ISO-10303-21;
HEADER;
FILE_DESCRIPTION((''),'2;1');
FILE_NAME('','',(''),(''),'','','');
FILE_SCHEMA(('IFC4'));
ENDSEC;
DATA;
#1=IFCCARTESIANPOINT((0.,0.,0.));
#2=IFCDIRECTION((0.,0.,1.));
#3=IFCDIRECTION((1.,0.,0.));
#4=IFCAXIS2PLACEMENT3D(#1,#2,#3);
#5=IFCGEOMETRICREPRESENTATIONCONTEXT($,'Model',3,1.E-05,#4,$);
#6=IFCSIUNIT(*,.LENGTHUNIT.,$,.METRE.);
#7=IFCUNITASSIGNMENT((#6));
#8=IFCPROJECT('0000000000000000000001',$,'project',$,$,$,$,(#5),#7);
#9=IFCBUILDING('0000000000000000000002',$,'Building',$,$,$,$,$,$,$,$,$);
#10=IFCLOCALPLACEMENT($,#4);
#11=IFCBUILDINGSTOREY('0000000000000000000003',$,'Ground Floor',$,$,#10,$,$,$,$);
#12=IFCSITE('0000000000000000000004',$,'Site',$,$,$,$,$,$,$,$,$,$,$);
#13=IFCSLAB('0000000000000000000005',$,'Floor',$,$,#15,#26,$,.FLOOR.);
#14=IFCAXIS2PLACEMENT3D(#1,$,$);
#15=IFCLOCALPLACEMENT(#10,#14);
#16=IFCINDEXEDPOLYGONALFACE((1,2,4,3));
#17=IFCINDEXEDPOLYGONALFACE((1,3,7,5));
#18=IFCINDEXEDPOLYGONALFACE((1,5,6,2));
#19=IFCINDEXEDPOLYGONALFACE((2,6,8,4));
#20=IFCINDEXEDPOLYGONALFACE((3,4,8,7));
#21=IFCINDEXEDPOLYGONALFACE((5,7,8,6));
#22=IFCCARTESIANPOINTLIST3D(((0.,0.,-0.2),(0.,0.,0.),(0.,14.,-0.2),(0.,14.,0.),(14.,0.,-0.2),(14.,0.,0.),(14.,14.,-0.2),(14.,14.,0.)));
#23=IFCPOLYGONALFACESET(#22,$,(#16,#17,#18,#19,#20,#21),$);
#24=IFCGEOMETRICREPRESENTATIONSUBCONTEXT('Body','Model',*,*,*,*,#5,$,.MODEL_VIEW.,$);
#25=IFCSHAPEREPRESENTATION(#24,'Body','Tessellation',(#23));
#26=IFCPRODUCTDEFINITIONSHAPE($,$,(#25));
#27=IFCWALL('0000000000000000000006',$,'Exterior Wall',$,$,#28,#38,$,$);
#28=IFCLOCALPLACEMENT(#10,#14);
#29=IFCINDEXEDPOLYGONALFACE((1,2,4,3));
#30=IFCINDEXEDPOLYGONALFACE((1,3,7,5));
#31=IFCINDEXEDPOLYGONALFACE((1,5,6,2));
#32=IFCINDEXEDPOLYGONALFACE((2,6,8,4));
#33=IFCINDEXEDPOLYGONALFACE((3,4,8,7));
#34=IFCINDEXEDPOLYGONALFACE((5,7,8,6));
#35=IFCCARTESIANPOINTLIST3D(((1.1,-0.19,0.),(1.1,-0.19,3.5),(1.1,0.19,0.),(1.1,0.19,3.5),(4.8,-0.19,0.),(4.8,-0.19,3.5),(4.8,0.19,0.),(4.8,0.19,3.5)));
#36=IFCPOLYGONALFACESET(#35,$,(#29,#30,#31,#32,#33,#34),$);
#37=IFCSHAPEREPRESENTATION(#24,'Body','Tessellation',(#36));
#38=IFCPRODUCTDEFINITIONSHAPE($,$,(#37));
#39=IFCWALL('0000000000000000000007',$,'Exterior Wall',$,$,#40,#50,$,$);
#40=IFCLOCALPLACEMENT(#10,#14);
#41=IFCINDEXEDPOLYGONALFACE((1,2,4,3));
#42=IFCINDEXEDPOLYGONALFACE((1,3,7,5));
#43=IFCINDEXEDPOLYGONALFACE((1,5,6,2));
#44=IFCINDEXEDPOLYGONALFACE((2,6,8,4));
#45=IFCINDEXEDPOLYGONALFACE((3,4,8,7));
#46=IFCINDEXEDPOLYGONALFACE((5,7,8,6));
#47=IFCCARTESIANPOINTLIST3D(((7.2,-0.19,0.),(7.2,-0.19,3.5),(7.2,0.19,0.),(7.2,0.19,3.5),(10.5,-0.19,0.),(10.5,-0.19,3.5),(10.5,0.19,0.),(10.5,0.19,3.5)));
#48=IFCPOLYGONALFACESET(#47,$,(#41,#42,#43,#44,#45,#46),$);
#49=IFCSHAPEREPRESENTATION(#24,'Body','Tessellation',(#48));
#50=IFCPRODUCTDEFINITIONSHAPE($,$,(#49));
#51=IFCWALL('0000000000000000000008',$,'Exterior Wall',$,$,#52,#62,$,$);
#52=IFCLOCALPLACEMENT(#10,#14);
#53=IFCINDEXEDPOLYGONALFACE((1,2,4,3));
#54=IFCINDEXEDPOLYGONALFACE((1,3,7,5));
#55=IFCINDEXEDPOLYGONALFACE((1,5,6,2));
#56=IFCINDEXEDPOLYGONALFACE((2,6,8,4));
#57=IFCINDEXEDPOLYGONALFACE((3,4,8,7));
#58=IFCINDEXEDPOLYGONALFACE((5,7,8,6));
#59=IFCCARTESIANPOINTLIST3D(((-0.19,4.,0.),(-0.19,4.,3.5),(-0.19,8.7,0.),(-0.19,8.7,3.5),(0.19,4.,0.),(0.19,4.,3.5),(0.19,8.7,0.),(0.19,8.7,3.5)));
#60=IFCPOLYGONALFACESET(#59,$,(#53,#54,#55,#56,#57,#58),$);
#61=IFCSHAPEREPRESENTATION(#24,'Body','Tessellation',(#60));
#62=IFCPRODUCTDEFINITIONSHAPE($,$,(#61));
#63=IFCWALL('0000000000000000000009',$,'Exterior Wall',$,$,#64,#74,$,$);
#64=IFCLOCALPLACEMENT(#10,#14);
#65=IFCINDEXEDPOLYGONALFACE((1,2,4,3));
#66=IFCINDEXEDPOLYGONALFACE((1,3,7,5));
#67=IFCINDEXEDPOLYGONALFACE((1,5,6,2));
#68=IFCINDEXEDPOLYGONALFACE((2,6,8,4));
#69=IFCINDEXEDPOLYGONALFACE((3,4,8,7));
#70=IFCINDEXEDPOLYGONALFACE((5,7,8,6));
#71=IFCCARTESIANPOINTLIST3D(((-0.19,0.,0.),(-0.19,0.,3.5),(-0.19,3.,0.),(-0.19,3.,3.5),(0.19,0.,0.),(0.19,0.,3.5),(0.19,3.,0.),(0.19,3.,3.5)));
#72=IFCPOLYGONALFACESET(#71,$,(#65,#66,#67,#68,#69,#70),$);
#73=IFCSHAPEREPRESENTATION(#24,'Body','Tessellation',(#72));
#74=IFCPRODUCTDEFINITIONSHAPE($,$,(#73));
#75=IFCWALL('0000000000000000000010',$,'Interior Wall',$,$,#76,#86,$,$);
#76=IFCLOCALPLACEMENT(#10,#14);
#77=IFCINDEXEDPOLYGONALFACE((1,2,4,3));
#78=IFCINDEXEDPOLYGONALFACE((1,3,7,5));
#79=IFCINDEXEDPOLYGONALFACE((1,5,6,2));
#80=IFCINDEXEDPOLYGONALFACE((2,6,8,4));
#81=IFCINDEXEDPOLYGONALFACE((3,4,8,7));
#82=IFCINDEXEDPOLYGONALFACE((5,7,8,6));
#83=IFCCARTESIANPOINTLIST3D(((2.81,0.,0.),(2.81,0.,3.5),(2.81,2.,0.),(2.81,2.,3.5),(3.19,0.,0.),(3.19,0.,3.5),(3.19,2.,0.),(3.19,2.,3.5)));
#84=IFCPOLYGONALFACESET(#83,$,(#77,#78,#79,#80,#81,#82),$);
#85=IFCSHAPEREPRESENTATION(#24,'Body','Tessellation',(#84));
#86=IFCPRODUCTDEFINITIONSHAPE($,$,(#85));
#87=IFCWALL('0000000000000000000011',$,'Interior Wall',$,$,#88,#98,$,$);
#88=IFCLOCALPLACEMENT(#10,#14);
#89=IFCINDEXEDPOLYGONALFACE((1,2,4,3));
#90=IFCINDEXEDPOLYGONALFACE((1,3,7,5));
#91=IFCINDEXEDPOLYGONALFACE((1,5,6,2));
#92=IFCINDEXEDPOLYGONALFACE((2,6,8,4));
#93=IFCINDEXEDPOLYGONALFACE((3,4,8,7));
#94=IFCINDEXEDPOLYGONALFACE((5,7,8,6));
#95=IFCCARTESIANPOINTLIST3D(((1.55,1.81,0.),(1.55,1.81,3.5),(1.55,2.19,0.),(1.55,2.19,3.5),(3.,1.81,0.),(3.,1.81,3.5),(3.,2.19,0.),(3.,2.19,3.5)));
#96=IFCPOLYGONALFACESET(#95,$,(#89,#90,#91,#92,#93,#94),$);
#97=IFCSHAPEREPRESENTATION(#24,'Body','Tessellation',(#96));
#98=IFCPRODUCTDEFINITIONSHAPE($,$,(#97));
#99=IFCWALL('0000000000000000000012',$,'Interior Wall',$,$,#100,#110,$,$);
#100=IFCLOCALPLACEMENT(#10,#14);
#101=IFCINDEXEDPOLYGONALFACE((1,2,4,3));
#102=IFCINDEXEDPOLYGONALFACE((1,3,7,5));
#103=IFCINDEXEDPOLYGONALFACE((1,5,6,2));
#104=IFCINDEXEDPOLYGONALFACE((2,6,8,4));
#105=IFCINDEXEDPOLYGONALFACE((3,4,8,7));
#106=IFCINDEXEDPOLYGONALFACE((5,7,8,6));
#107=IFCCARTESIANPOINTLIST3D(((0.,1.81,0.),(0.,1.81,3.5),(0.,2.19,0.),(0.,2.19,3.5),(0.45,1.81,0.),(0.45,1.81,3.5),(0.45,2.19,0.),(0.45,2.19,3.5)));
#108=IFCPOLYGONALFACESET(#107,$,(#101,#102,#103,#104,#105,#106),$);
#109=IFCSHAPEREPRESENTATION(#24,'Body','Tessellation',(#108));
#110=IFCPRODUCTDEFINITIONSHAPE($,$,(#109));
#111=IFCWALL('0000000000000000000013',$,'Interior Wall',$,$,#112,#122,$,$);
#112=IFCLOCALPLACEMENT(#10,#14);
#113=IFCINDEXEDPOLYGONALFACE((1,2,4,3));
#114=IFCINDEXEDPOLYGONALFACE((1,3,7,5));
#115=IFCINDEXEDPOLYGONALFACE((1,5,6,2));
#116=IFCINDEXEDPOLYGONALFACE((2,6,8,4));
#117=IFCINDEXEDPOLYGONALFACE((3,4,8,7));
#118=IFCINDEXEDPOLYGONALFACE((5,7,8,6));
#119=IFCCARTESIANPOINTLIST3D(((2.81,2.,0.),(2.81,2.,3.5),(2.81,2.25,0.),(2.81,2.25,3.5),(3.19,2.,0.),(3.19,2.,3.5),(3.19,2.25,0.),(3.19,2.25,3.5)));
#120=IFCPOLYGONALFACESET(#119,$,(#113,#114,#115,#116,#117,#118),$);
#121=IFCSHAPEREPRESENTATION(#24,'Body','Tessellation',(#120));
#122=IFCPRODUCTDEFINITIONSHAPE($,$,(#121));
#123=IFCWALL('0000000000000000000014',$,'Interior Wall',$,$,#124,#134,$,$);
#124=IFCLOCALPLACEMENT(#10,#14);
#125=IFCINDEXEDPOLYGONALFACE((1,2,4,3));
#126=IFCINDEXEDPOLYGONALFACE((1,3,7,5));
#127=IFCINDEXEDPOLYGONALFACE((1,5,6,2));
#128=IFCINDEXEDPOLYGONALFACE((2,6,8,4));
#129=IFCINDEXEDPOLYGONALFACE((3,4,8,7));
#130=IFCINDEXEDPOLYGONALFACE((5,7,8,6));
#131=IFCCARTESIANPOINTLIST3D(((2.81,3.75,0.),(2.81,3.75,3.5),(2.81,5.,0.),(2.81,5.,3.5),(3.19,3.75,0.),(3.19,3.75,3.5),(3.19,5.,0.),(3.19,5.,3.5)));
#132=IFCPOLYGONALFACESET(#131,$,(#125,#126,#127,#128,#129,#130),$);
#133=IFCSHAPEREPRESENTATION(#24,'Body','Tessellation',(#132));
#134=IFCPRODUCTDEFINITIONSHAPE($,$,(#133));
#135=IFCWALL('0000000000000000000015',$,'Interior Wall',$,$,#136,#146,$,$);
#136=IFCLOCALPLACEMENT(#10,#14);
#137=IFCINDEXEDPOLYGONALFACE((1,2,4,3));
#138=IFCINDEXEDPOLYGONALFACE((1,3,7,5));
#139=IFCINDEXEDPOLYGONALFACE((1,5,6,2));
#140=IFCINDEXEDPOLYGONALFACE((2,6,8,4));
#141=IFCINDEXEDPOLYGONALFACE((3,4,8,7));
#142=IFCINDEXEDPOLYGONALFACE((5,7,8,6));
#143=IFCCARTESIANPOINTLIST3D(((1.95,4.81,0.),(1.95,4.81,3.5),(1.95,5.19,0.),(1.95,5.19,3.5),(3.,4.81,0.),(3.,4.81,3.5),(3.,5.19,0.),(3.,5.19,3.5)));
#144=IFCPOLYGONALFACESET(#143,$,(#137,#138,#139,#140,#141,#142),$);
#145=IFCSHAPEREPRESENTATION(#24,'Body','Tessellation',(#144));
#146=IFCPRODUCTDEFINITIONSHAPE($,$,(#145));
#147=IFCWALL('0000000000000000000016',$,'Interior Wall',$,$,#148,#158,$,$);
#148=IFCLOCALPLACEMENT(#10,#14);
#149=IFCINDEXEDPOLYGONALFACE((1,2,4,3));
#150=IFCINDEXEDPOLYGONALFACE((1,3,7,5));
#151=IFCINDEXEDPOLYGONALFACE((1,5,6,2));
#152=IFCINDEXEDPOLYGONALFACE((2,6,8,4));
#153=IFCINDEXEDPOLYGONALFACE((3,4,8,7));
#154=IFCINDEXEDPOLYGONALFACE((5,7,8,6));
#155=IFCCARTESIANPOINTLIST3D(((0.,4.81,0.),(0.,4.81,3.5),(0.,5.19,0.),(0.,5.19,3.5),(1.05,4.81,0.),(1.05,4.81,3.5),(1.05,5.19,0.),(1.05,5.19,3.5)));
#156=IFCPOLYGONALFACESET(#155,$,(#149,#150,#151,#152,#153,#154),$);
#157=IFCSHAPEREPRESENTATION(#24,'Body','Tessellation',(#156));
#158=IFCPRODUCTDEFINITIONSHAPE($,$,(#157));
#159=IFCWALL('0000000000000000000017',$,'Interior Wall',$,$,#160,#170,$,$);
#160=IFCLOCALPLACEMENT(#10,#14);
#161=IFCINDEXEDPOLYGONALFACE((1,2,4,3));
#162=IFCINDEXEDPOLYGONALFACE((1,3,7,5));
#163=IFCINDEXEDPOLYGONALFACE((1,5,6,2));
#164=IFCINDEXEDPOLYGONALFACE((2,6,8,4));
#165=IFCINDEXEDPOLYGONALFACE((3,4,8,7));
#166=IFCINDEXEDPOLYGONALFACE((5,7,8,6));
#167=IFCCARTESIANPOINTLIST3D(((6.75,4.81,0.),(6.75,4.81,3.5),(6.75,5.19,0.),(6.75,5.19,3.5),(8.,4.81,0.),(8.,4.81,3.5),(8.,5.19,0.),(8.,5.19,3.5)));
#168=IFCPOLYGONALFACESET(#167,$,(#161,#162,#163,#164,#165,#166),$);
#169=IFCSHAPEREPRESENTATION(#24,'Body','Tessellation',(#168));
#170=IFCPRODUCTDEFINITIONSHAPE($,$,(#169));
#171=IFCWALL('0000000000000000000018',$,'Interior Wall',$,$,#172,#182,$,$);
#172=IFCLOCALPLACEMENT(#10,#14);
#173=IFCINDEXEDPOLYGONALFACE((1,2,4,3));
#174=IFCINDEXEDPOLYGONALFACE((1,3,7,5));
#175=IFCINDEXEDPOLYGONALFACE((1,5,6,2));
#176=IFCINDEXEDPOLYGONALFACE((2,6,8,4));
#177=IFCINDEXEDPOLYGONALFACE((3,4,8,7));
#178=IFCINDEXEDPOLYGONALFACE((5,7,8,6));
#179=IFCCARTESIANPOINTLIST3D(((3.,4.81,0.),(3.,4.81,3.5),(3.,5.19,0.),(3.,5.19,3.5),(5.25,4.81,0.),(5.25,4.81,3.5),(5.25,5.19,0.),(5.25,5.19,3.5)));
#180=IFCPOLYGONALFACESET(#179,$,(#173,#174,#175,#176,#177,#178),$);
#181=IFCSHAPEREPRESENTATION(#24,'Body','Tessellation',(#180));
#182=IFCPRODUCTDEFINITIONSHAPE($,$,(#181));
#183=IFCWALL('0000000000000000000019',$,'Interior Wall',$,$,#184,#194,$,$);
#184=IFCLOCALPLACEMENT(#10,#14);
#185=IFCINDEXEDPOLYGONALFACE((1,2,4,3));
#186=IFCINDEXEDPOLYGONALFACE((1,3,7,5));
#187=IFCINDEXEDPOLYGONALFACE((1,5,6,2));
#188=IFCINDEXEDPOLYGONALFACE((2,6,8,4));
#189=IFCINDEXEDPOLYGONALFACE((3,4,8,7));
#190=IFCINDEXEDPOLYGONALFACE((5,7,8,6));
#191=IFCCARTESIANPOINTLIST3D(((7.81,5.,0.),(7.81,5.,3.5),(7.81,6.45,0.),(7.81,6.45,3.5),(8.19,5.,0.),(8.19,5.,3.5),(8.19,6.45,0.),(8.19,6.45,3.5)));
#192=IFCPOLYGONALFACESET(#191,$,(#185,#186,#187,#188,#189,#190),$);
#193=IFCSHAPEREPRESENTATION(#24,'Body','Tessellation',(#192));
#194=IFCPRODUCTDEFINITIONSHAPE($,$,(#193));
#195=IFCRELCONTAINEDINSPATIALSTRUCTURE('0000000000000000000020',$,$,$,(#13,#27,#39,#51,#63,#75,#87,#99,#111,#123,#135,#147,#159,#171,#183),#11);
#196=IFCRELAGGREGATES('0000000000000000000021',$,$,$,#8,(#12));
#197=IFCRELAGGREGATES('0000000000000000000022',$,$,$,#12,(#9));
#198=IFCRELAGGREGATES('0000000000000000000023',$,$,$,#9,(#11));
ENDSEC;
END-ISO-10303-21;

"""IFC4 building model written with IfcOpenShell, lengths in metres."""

from ifc_helpers import new_model, si_unit, frame, origin_with_axes, place, context, subcontext, project, spatial, indexed_curve, outline, extrude, element, save


model = new_model("IFC4")

# Units and contexts
model_context = context("Model", 3, precision=1e-05, world=origin_with_axes())
body_context = subcontext(model_context, "Body", "Model", "MODEL_VIEW")
ifc_project = project(units=[si_unit("LENGTHUNIT", "METRE")], contexts=[model_context])

# Site, building, storey
site = spatial("IfcSite", under=ifc_project, Name="Site")
building = spatial("IfcBuilding", under=site, Name="Building")
storey_placement = place(None, origin_with_axes())
storey = spatial("IfcBuildingStorey", under=building, at=storey_placement, Name="Ground Floor")

# Slab
slab_placement = place(storey_placement, frame((0.0, 0.0, -0.2), z_axis=(0.0, 0.0, 1.0), x_axis=(1.0, 0.0, 0.0)))
element("IfcSlab", 1, at=slab_placement, inside=storey, Name="Floor", PredefinedType="FLOOR", context=body_context, shape_type="SweptSolid", body=[
    extrude(outline(indexed_curve([(0.0, 0.0), (14.0, 0.0), (14.0, 14.0), (0.0, 14.0)])), None, (0.0, 0.0, 1.0), 0.2),
])

# Walls
wall_1_placement = place(storey_placement, frame((1.1, 0.0, 0.0), z_axis=(0.0, 0.0, 1.0), x_axis=(1.0, 0.0, 0.0)))
element("IfcWall", 2, at=wall_1_placement, inside=storey, Name="Exterior Wall", context=body_context, shape_type="SweptSolid", body=[
    extrude(outline(indexed_curve([(0.0, 0.0), (0.0, 0.38), (3.7, 0.38), (3.7, 0.0), (0.0, 0.0)], self_intersect=False)), frame((0.0, -0.19, 0.0), z_axis=(0.0, 0.0, 1.0), x_axis=(1.0, 0.0, 0.0)), (0.0, 0.0, 1.0), 3.5),
])
wall_2_placement = place(storey_placement, frame((7.2, 0.0, 0.0), z_axis=(0.0, 0.0, 1.0), x_axis=(1.0, 0.0, 0.0)))
element("IfcWall", 3, at=wall_2_placement, inside=storey, Name="Exterior Wall", context=body_context, shape_type="SweptSolid", body=[
    extrude(outline(indexed_curve([(0.0, 0.0), (0.0, 0.38), (3.3, 0.38), (3.3, 0.0), (0.0, 0.0)], self_intersect=False)), frame((0.0, -0.19, 0.0), z_axis=(0.0, 0.0, 1.0), x_axis=(1.0, 0.0, 0.0)), (0.0, 0.0, 1.0), 3.5),
])
wall_3_placement = place(storey_placement, frame((0.0, 8.7, 0.0), z_axis=(0.0, 0.0, 1.0), x_axis=(0.0, -1.0, 0.0)))
element("IfcWall", 4, at=wall_3_placement, inside=storey, Name="Exterior Wall", context=body_context, shape_type="SweptSolid", body=[
    extrude(outline(indexed_curve([(0.0, 0.0), (0.0, 0.38), (4.7, 0.38), (4.7, 0.0), (0.0, 0.0)], self_intersect=False)), frame((0.0, -0.19, 0.0), z_axis=(0.0, 0.0, 1.0), x_axis=(1.0, 0.0, 0.0)), (0.0, 0.0, 1.0), 3.5),
])
wall_4_placement = place(storey_placement, frame((0.0, 3.0, 0.0), z_axis=(0.0, 0.0, 1.0), x_axis=(0.0, -1.0, 0.0)))
element("IfcWall", 5, at=wall_4_placement, inside=storey, Name="Exterior Wall", context=body_context, shape_type="SweptSolid", body=[
    extrude(outline(indexed_curve([(0.0, 0.0), (0.0, 0.38), (3.0, 0.38), (3.0, 0.0), (0.0, 0.0)], self_intersect=False)), frame((0.0, -0.19, 0.0), z_axis=(0.0, 0.0, 1.0), x_axis=(1.0, 0.0, 0.0)), (0.0, 0.0, 1.0), 3.5),
])
wall_5_placement = place(storey_placement, frame((3.0, 0.0, 0.0), z_axis=(0.0, 0.0, 1.0), x_axis=(0.0, 1.0, 0.0)))
element("IfcWall", 6, at=wall_5_placement, inside=storey, Name="Interior Wall", context=body_context, shape_type="SweptSolid", body=[
    extrude(outline(indexed_curve([(0.0, 0.0), (0.0, 0.38), (2.0, 0.38), (2.0, 0.0), (0.0, 0.0)], self_intersect=False)), frame((0.0, -0.19, 0.0), z_axis=(0.0, 0.0, 1.0), x_axis=(1.0, 0.0, 0.0)), (0.0, 0.0, 1.0), 3.5),
])
wall_6_placement = place(storey_placement, frame((3.0, 2.0, 0.0), z_axis=(0.0, 0.0, 1.0), x_axis=(-1.0, 0.0, 0.0)))
element("IfcWall", 7, at=wall_6_placement, inside=storey, Name="Interior Wall", context=body_context, shape_type="SweptSolid", body=[
    extrude(outline(indexed_curve([(0.0, 0.0), (0.0, 0.38), (1.45, 0.38), (1.45, 0.0), (0.0, 0.0)], self_intersect=False)), frame((0.0, -0.19, 0.0), z_axis=(0.0, 0.0, 1.0), x_axis=(1.0, 0.0, 0.0)), (0.0, 0.0, 1.0), 3.5),
])
wall_7_placement = place(storey_placement, frame((0.45, 2.0, 0.0), z_axis=(0.0, 0.0, 1.0), x_axis=(-1.0, 0.0, 0.0)))
element("IfcWall", 8, at=wall_7_placement, inside=storey, Name="Interior Wall", context=body_context, shape_type="SweptSolid", body=[
    extrude(outline(indexed_curve([(0.0, 0.0), (0.0, 0.38), (0.45, 0.38), (0.45, 0.0), (0.0, 0.0)], self_intersect=False)), frame((0.0, -0.19, 0.0), z_axis=(0.0, 0.0, 1.0), x_axis=(1.0, 0.0, 0.0)), (0.0, 0.0, 1.0), 3.5),
])
wall_8_placement = place(storey_placement, frame((3.0, 2.0, 0.0), z_axis=(0.0, 0.0, 1.0), x_axis=(0.0, 1.0, 0.0)))
element("IfcWall", 9, at=wall_8_placement, inside=storey, Name="Interior Wall", context=body_context, shape_type="SweptSolid", body=[
    extrude(outline(indexed_curve([(0.0, 0.0), (0.0, 0.38), (0.25, 0.38), (0.25, 0.0), (0.0, 0.0)], self_intersect=False)), frame((0.0, -0.19, 0.0), z_axis=(0.0, 0.0, 1.0), x_axis=(1.0, 0.0, 0.0)), (0.0, 0.0, 1.0), 3.5),
])
wall_9_placement = place(storey_placement, frame((3.0, 3.75, 0.0), z_axis=(0.0, 0.0, 1.0), x_axis=(0.0, 1.0, 0.0)))
element("IfcWall", 10, at=wall_9_placement, inside=storey, Name="Interior Wall", context=body_context, shape_type="SweptSolid", body=[
    extrude(outline(indexed_curve([(0.0, 0.0), (0.0, 0.38), (1.25, 0.38), (1.25, 0.0), (0.0, 0.0)], self_intersect=False)), frame((0.0, -0.19, 0.0), z_axis=(0.0, 0.0, 1.0), x_axis=(1.0, 0.0, 0.0)), (0.0, 0.0, 1.0), 3.5),
])
for number, where, z_axis, x_axis, name in (
    (11, (3.0, 5.0, 0.0), (0.0, 0.0, 1.0), (-1.0, 0.0, 0.0), "Interior Wall"),
    (12, (1.05, 5.0, 0.0), (0.0, 0.0, 1.0), (-1.0, 0.0, 0.0), "Interior Wall"),
):
    element("IfcWall", number, at=place(storey_placement, frame(where, z_axis=z_axis, x_axis=x_axis)), inside=storey, Name=name, context=body_context, shape_type="SweptSolid", body=[
        extrude(outline(indexed_curve([(0.0, 0.0), (0.0, 0.38), (1.05, 0.38), (1.05, 0.0), (0.0, 0.0)], self_intersect=False)), frame((0.0, -0.19, 0.0), z_axis=(0.0, 0.0, 1.0), x_axis=(1.0, 0.0, 0.0)), (0.0, 0.0, 1.0), 3.5),
    ])
wall_10_placement = place(storey_placement, frame((8.0, 5.0, 0.0), z_axis=(0.0, 0.0, 1.0), x_axis=(-1.0, 0.0, 0.0)))
element("IfcWall", 13, at=wall_10_placement, inside=storey, Name="Interior Wall", context=body_context, shape_type="SweptSolid", body=[
    extrude(outline(indexed_curve([(0.0, 0.0), (0.0, 0.38), (1.25, 0.38), (1.25, 0.0), (0.0, 0.0)], self_intersect=False)), frame((0.0, -0.19, 0.0), z_axis=(0.0, 0.0, 1.0), x_axis=(1.0, 0.0, 0.0)), (0.0, 0.0, 1.0), 3.5),
])
wall_11_placement = place(storey_placement, frame((5.25, 5.0, 0.0), z_axis=(0.0, 0.0, 1.0), x_axis=(-1.0, 0.0, 0.0)))
element("IfcWall", 14, at=wall_11_placement, inside=storey, Name="Interior Wall", context=body_context, shape_type="SweptSolid", body=[
    extrude(outline(indexed_curve([(0.0, 0.0), (0.0, 0.38), (2.25, 0.38), (2.25, 0.0), (0.0, 0.0)], self_intersect=False)), frame((0.0, -0.19, 0.0), z_axis=(0.0, 0.0, 1.0), x_axis=(1.0, 0.0, 0.0)), (0.0, 0.0, 1.0), 3.5),
])
wall_12_placement = place(storey_placement, frame((8.0, 5.0, 0.0), z_axis=(0.0, 0.0, 1.0), x_axis=(0.0, 1.0, 0.0)))
element("IfcWall", 15, at=wall_12_placement, inside=storey, Name="Interior Wall", context=body_context, shape_type="SweptSolid", body=[
    extrude(outline(indexed_curve([(0.0, 0.0), (0.0, 0.38), (1.45, 0.38), (1.45, 0.0), (0.0, 0.0)], self_intersect=False)), frame((0.0, -0.19, 0.0), z_axis=(0.0, 0.0, 1.0), x_axis=(1.0, 0.0, 0.0)), (0.0, 0.0, 1.0), 3.5),
])

save(model, "model.ifc")
